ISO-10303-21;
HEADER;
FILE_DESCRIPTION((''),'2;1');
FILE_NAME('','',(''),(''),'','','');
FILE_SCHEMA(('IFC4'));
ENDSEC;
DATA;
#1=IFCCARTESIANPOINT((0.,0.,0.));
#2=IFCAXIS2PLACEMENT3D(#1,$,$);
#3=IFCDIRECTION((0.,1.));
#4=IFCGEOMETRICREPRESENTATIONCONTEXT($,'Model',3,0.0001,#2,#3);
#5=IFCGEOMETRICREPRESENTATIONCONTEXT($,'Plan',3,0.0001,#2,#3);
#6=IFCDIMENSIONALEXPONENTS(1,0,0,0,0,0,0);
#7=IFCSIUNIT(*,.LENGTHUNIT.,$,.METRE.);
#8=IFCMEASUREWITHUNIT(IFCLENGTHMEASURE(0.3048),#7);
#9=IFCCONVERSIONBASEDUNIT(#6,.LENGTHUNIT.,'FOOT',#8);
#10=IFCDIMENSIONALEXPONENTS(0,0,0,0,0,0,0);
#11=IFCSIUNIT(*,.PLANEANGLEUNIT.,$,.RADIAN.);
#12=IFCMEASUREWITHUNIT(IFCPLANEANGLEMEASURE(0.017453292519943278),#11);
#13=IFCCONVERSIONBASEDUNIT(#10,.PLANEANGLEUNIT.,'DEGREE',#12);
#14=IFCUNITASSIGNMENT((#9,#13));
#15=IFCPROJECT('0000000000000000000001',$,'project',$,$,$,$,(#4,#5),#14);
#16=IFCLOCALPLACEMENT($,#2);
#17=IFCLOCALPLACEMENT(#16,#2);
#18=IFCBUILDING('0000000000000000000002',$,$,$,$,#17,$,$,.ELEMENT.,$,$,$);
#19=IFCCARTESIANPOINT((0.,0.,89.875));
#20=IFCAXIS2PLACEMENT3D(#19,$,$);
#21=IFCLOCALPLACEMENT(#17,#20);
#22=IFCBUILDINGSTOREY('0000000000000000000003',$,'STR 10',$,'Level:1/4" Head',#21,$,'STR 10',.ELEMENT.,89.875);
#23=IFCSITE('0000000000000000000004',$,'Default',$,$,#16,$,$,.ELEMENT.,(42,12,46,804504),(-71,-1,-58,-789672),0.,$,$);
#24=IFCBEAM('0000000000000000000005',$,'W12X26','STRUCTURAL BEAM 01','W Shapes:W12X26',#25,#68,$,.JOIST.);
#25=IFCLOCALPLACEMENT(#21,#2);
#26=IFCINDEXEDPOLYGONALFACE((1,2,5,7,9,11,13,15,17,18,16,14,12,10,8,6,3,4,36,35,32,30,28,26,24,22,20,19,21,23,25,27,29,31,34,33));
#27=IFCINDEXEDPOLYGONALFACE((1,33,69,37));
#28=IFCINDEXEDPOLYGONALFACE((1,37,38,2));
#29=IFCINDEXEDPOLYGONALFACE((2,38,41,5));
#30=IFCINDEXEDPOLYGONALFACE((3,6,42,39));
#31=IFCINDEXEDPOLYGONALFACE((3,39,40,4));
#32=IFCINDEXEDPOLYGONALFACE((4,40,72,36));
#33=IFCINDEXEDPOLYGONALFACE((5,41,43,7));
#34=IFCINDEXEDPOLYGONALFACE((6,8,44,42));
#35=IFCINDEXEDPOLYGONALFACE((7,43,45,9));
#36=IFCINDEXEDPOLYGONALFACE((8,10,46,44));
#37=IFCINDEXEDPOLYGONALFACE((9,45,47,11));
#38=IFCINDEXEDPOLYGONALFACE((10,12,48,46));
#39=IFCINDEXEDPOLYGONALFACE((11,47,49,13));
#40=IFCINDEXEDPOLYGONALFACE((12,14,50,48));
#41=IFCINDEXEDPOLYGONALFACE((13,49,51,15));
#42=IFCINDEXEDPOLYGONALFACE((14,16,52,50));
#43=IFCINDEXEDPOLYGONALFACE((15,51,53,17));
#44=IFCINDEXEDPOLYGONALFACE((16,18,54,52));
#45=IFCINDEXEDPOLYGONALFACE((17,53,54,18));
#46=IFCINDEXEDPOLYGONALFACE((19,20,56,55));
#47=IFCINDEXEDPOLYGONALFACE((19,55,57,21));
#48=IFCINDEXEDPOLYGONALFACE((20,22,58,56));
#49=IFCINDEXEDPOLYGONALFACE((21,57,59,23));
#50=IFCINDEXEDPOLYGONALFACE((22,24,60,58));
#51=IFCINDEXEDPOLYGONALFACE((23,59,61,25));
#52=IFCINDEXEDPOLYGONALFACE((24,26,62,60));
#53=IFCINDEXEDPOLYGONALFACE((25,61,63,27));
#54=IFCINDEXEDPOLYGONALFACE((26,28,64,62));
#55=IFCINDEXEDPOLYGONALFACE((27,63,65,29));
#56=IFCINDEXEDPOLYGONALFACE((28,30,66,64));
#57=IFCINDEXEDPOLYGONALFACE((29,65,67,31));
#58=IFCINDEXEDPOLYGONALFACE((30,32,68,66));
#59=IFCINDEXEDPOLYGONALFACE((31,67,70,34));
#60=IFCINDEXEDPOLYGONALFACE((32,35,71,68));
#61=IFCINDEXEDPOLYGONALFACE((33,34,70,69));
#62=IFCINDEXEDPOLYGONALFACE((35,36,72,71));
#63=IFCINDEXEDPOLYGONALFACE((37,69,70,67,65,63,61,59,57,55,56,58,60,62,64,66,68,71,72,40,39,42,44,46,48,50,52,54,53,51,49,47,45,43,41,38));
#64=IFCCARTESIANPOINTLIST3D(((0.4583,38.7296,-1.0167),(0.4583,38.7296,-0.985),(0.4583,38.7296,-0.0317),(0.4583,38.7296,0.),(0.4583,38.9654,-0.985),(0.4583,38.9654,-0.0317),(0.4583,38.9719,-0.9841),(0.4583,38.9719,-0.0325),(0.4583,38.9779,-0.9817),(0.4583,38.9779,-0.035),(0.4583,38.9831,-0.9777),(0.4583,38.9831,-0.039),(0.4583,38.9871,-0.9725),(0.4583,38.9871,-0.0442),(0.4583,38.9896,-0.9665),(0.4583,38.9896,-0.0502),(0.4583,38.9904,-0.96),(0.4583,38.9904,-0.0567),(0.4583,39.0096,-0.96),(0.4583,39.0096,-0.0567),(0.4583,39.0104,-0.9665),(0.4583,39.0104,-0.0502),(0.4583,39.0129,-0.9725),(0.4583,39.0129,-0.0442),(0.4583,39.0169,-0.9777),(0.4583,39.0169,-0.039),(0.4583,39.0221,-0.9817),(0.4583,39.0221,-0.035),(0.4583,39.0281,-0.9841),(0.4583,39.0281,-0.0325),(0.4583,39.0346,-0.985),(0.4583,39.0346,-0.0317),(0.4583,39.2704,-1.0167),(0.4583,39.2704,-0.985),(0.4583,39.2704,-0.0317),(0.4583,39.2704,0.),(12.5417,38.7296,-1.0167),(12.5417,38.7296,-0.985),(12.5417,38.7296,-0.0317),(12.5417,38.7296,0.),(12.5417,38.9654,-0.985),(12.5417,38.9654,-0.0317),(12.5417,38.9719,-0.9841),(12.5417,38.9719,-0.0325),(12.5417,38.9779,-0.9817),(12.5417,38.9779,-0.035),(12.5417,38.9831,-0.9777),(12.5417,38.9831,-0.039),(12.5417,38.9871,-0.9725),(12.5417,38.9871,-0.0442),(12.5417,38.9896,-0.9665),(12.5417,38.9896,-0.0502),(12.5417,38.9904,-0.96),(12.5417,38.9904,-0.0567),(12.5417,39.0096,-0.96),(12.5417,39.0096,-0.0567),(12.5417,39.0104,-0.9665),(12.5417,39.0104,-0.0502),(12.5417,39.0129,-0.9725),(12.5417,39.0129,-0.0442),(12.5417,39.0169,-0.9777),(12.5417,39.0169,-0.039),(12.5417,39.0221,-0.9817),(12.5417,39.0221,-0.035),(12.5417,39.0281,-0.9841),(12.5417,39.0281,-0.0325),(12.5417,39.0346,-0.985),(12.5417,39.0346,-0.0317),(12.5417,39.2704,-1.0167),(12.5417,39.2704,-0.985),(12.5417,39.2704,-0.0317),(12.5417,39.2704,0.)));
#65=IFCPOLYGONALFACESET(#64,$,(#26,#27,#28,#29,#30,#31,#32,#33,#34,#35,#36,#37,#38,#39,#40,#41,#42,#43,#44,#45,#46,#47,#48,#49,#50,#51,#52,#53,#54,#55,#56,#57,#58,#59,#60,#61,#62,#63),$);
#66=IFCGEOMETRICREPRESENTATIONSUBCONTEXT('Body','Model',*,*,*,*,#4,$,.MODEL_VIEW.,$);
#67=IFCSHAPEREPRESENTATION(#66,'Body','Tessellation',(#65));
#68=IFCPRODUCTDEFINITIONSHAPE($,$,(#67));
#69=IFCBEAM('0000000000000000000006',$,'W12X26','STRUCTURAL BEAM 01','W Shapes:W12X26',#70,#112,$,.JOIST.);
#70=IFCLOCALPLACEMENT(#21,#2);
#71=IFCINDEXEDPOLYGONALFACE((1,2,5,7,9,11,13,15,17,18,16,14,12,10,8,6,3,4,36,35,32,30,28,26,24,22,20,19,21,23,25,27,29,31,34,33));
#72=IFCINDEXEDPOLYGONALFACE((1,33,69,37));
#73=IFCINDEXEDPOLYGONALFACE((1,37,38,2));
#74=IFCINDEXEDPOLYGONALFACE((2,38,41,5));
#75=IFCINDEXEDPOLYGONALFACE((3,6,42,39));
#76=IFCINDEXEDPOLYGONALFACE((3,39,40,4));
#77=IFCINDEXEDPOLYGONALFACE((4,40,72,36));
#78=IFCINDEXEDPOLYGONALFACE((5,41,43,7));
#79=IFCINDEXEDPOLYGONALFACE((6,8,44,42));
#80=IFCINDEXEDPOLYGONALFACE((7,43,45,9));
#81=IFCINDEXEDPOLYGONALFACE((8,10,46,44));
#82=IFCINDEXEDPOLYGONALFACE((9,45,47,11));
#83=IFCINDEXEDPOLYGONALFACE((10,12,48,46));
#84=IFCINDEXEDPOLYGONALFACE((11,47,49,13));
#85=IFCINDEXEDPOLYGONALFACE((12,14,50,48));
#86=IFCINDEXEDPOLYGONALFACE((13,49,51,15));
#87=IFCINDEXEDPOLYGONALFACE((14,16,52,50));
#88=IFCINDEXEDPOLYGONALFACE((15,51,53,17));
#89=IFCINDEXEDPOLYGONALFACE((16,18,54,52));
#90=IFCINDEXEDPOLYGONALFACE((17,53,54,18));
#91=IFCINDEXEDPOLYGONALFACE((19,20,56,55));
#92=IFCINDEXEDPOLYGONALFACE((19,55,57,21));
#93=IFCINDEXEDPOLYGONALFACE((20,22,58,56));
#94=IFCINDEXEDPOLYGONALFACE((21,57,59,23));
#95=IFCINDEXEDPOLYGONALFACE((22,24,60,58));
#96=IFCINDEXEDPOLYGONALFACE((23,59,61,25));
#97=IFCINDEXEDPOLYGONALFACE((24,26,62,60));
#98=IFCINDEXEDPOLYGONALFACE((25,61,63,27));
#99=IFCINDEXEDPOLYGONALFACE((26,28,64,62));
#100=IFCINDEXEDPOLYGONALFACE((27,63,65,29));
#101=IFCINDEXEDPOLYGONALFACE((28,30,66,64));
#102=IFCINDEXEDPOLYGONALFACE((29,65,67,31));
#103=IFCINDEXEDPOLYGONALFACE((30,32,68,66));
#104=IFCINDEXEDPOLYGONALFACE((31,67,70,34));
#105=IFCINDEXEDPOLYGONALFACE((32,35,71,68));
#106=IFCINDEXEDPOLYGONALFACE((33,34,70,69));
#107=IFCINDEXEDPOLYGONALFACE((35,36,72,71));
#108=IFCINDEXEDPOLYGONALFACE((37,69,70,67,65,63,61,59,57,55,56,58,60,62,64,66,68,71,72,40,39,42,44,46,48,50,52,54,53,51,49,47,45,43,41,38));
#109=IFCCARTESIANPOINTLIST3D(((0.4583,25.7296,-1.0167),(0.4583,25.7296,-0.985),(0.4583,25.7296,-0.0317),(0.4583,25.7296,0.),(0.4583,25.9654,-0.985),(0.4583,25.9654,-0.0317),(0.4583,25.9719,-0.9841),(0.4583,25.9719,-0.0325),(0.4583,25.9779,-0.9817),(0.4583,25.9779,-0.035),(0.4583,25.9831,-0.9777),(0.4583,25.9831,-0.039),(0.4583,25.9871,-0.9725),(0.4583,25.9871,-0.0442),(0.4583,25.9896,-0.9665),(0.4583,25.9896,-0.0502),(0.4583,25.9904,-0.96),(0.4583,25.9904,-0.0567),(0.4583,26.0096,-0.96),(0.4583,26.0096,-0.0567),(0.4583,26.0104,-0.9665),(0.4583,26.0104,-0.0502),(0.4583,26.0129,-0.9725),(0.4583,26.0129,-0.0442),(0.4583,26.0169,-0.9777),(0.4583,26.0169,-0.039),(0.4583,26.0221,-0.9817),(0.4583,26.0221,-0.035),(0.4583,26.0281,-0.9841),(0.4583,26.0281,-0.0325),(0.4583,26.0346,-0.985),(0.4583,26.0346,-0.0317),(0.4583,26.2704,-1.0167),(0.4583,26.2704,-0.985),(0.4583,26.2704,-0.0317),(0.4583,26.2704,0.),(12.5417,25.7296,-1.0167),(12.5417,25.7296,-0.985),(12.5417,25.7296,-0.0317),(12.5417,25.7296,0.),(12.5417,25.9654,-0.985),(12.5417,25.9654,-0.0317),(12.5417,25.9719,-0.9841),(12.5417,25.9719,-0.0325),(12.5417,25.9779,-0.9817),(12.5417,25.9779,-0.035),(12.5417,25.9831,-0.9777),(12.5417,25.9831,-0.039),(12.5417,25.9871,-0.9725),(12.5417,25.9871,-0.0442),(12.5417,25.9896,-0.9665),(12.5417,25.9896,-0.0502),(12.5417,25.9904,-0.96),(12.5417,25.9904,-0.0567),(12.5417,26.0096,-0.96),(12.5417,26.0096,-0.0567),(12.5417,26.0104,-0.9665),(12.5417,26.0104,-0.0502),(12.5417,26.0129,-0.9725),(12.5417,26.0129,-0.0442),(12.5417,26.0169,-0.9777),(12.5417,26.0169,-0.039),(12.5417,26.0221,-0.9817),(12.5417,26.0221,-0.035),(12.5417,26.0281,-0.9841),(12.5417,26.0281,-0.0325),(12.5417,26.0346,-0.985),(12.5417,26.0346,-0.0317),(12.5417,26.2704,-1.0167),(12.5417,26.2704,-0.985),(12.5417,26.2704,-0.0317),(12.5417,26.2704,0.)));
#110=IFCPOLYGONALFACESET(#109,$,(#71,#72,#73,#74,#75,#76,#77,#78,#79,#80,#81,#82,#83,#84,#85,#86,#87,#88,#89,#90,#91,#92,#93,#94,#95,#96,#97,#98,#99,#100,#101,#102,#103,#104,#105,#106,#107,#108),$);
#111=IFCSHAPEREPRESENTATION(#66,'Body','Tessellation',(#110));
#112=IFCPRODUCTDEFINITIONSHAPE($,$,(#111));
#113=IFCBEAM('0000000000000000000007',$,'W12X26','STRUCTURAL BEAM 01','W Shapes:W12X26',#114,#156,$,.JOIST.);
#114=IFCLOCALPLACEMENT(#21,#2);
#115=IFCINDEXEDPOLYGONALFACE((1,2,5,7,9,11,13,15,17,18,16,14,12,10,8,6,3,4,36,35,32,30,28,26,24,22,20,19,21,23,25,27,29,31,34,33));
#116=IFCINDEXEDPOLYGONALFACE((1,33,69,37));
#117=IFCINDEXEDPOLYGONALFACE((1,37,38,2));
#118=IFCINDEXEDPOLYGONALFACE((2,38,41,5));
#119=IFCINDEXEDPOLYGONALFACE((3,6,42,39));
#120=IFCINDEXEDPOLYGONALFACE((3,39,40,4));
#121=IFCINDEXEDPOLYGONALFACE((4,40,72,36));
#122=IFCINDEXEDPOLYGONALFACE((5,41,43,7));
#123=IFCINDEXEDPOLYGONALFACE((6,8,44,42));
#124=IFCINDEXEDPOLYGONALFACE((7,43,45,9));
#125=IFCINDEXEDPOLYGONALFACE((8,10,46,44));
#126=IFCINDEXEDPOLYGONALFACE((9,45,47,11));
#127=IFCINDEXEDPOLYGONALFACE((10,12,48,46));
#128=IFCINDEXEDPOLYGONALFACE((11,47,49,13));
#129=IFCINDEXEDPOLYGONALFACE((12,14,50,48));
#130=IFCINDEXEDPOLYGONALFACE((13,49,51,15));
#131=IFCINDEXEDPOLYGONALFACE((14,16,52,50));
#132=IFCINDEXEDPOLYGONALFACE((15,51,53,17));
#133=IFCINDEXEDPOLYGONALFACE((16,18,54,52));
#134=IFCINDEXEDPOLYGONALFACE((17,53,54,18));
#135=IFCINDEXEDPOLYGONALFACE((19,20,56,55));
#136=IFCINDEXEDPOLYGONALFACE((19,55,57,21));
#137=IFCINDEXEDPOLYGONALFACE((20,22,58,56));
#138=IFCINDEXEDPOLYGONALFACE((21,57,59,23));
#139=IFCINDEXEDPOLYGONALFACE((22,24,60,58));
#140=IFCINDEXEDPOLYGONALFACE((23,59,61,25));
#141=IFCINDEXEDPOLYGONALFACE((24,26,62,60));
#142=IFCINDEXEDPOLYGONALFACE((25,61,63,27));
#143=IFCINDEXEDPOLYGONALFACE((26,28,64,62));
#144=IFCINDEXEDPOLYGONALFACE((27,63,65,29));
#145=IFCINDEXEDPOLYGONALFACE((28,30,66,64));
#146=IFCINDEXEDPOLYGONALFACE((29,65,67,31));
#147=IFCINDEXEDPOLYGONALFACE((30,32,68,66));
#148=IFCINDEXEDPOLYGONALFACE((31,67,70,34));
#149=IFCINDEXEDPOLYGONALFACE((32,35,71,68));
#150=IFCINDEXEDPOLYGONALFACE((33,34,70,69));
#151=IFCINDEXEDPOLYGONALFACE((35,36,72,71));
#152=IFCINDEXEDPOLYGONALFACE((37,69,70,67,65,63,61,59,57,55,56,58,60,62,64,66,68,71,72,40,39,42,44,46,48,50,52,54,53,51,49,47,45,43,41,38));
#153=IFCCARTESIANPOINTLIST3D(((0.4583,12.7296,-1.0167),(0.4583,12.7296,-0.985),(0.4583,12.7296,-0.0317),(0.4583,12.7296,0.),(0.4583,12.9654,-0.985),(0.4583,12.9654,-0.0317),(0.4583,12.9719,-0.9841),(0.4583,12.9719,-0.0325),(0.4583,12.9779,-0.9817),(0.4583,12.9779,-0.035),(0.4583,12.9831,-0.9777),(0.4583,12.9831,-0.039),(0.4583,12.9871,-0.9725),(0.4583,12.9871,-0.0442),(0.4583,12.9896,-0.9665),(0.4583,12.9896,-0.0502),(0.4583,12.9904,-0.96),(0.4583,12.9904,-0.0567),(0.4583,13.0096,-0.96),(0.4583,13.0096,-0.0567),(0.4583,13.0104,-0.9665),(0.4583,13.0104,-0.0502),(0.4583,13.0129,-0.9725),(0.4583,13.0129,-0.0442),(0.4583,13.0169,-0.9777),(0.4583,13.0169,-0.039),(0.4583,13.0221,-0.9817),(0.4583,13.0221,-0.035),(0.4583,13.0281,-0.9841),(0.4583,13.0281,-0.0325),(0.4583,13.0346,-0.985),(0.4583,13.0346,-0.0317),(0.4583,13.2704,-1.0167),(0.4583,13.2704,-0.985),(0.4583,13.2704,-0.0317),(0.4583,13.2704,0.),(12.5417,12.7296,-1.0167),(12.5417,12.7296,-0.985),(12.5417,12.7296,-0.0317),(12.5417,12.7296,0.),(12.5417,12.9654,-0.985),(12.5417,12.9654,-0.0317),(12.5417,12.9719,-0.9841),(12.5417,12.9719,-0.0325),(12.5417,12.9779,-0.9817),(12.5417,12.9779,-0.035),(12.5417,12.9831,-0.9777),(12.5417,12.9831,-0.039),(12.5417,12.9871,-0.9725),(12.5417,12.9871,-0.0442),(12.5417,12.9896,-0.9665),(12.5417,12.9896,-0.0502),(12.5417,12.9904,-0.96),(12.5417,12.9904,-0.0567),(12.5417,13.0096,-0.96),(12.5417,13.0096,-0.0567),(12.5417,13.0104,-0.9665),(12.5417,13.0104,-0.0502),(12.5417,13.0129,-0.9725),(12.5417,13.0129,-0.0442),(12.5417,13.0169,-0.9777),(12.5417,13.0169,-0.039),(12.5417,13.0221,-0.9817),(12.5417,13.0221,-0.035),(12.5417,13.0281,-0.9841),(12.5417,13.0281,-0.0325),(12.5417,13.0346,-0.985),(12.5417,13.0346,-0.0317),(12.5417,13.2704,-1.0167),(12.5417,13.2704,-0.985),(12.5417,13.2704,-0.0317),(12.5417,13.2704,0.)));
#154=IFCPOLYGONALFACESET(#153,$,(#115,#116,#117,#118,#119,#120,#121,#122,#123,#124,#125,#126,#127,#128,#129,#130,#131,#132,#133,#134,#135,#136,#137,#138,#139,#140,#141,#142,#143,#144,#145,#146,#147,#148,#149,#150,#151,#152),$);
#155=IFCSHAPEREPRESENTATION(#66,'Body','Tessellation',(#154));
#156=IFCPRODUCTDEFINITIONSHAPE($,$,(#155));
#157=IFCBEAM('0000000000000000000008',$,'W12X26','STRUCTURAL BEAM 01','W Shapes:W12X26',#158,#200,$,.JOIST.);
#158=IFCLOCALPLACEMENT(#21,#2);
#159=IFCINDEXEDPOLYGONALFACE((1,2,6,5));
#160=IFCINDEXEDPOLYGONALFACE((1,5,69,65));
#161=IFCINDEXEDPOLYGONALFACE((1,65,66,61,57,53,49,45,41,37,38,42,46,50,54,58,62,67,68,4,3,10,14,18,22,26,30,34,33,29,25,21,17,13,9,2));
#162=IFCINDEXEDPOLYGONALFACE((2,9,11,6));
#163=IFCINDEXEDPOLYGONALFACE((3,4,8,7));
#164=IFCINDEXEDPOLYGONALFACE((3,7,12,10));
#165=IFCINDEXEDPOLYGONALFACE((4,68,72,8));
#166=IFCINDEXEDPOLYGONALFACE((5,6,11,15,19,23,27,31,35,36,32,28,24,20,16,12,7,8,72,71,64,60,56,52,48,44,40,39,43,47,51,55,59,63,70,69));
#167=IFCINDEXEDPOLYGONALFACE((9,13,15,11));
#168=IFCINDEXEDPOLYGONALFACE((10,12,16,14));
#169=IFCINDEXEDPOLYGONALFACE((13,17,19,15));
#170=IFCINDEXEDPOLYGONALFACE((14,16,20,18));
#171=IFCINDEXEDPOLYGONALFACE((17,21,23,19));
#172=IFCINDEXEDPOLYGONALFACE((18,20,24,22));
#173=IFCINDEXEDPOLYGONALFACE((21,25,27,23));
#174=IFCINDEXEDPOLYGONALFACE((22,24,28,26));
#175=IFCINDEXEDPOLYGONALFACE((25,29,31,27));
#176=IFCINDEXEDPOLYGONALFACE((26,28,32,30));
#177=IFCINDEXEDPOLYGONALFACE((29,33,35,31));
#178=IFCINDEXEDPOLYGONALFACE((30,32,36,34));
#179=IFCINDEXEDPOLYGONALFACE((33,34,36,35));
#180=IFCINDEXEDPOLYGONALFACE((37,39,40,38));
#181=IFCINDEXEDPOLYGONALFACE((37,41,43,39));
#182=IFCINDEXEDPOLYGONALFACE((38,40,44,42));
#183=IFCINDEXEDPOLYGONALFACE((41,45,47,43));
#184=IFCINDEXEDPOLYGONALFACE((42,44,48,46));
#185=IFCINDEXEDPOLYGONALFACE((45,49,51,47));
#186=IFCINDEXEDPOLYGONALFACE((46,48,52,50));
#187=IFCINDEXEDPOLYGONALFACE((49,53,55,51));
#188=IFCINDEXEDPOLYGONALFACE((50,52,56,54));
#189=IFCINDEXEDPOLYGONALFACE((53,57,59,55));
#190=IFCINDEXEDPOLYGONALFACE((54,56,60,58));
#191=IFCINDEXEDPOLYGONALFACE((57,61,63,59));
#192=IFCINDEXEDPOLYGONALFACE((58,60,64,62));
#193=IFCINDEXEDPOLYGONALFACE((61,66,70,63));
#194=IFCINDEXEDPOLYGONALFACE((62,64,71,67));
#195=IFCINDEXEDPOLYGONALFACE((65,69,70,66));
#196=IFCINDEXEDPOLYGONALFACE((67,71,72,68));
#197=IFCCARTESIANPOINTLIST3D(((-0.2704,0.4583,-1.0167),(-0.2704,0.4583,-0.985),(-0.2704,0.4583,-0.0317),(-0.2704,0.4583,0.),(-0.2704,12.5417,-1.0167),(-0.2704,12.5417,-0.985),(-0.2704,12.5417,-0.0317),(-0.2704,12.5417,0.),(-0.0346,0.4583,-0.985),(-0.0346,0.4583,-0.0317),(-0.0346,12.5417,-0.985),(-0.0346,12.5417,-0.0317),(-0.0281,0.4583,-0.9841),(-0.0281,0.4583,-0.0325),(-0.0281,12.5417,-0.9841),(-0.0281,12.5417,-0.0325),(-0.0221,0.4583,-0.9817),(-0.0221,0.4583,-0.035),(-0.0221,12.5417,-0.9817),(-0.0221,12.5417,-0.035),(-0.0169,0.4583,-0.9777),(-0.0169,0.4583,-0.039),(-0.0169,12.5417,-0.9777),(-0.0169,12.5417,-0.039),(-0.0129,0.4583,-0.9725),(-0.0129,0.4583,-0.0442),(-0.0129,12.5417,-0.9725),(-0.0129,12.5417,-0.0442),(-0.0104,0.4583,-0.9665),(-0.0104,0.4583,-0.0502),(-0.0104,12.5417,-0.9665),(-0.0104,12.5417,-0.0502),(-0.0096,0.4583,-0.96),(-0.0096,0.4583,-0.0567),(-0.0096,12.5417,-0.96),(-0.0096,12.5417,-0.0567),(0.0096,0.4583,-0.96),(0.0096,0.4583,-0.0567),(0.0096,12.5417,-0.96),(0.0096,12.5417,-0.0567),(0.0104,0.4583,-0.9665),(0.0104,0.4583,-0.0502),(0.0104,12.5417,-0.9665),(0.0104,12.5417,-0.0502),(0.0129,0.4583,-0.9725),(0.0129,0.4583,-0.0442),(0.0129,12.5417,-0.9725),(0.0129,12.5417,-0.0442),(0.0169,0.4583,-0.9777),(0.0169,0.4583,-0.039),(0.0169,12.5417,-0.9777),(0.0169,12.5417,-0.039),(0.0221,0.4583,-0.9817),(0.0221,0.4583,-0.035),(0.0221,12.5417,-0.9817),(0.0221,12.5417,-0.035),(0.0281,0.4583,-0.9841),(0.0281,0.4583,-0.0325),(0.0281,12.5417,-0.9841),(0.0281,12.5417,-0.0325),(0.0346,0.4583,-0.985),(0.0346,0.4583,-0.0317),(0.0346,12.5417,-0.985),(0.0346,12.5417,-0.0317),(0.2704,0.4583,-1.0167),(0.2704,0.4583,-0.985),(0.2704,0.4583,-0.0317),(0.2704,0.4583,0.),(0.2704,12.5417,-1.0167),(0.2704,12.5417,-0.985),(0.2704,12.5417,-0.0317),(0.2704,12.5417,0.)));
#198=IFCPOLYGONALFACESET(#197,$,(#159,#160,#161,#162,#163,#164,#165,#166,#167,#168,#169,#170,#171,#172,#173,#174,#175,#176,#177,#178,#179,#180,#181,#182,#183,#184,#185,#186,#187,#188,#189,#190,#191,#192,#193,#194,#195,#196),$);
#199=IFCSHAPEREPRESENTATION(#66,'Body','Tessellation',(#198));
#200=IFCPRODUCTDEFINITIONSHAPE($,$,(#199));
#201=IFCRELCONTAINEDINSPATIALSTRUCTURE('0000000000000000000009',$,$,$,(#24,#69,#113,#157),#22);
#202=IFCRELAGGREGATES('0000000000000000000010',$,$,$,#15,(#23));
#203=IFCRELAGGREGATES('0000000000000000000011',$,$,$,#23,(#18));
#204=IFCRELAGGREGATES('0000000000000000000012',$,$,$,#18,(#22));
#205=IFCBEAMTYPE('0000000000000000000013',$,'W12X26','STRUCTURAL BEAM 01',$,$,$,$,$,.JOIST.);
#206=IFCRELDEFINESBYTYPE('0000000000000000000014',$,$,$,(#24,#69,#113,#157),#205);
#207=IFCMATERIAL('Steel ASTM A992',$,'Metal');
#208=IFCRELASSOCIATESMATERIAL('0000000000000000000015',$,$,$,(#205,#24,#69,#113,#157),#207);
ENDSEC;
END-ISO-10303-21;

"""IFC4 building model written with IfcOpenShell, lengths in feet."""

from ifc_helpers import new_model, entity, si_unit, converted_unit, direction, frame, origin, place, context, subcontext, project, spatial, line, arc, indexed_curve, outline, extrude, source, transform, mapped, material, type_object, type_shapes, element, save


model = new_model("IFC4")

# Units and contexts
model_context = context("Model", 3, precision=0.0001, world=origin(), true_north=direction((0.0, 1.0)))
plan_context = context("Plan", 3, precision=0.0001, world=origin(), true_north=direction((0.0, 1.0)))
body_context = subcontext(model_context, "Body", "Model", "MODEL_VIEW")
ifc_project = project(units=[converted_unit("LENGTHUNIT", "FOOT", entity("IfcLengthMeasure", 0.3048), si_unit("LENGTHUNIT", "METRE"), dimensions=[1, 0, 0, 0, 0, 0, 0]), converted_unit("PLANEANGLEUNIT", "DEGREE", entity("IfcPlaneAngleMeasure", 0.017453292519943278), si_unit("PLANEANGLEUNIT", "RADIAN"), dimensions=[0, 0, 0, 0, 0, 0, 0])], contexts=[model_context, plan_context])

# Site, building, storey
site_placement = place(None, origin())
site = spatial("IfcSite", under=ifc_project, at=site_placement, Name="Default", CompositionType="ELEMENT", RefLatitude=(42, 12, 46, 804504), RefLongitude=(-71, -1, -58, -789672), RefElevation=0.0)
building_placement = place(site_placement, origin())
building = spatial("IfcBuilding", under=site, at=building_placement, CompositionType="ELEMENT")
storey_placement = place(building_placement, frame((0.0, 0.0, 89.875)))
storey = spatial("IfcBuildingStorey", under=building, at=storey_placement, Name="STR 10", ObjectType="Level:1/4\" Head", LongName="STR 10", CompositionType="ELEMENT", Elevation=89.875)

# Beams
ifc_material = material(Name="Steel ASTM A992", Category="Metal")
beam_type_1 = type_object("IfcBeamType", Name="W12X26", Description="STRUCTURAL BEAM 01", PredefinedType="JOIST", material=ifc_material)
shared_shape_1 = source(origin(), body_context, "Body", "SweptSolid", [
    extrude(outline(indexed_curve([(-0.2704, -0.4767), (-0.2704, -0.5083), (0.2704, -0.5083), (0.2704, -0.4767), (0.0346, -0.4767), (0.0169, -0.4693), (0.0096, -0.4517), (0.0096, 0.4517), (0.0169, 0.4693), (0.0346, 0.4767), (0.2704, 0.4767), (0.2704, 0.5083), (-0.2704, 0.5083), (-0.2704, 0.4767), (-0.0346, 0.4767), (-0.0169, 0.4693), (-0.0096, 0.4517), (-0.0096, -0.4517), (-0.0169, -0.4693), (-0.0346, -0.4767)], segments=[line(1, 2, 3, 4, 5), arc(5, 6, 7), line(7, 8), arc(8, 9, 10), line(10, 11, 12, 13, 14, 15), arc(15, 16, 17), line(17, 18), arc(18, 19, 20), line(20, 1)], self_intersect=False)), frame((-6.1033, 0.0, 0.0), z_axis=(-1.0, 0.0, 0.0), x_axis=(0.0, -1.0, 0.0)), (0.0, 0.0, -1.0), 12.0833),
])
type_shapes(beam_type_1, [shared_shape_1])
for number, where, name in (
    (1, (6.5617, 39.0, -0.5083), "W12X26"),
    (2, (6.5617, 26.0, -0.5083), "W12X26"),
    (3, (6.5617, 13.0, -0.5083), "W12X26"),
):
    element("IfcBeam", number, at=place(storey_placement, frame(where)), inside=storey, type_object=beam_type_1, material=ifc_material, Name=name, Description="STRUCTURAL BEAM 01", ObjectType="W Shapes:W12X26", PredefinedType="JOIST", context=body_context, shape_type="MappedRepresentation", body=[
        mapped(shared_shape_1, transform((0.0, 0.0, 0.0), scale=1.0)),
    ])
for number, where, z_axis, x_axis, name in (
    (4, (0.0, 6.5617, -0.5083), (0.0, 0.0, 1.0), (0.0, 1.0, 0.0), "W12X26"),
):
    element("IfcBeam", number, at=place(storey_placement, frame(where, z_axis=z_axis, x_axis=x_axis)), inside=storey, type_object=beam_type_1, material=ifc_material, Name=name, Description="STRUCTURAL BEAM 01", ObjectType="W Shapes:W12X26", PredefinedType="JOIST", context=body_context, shape_type="MappedRepresentation", body=[
        mapped(shared_shape_1, transform((0.0, 0.0, 0.0), scale=1.0)),
    ])

save(model, "model.ifc")
